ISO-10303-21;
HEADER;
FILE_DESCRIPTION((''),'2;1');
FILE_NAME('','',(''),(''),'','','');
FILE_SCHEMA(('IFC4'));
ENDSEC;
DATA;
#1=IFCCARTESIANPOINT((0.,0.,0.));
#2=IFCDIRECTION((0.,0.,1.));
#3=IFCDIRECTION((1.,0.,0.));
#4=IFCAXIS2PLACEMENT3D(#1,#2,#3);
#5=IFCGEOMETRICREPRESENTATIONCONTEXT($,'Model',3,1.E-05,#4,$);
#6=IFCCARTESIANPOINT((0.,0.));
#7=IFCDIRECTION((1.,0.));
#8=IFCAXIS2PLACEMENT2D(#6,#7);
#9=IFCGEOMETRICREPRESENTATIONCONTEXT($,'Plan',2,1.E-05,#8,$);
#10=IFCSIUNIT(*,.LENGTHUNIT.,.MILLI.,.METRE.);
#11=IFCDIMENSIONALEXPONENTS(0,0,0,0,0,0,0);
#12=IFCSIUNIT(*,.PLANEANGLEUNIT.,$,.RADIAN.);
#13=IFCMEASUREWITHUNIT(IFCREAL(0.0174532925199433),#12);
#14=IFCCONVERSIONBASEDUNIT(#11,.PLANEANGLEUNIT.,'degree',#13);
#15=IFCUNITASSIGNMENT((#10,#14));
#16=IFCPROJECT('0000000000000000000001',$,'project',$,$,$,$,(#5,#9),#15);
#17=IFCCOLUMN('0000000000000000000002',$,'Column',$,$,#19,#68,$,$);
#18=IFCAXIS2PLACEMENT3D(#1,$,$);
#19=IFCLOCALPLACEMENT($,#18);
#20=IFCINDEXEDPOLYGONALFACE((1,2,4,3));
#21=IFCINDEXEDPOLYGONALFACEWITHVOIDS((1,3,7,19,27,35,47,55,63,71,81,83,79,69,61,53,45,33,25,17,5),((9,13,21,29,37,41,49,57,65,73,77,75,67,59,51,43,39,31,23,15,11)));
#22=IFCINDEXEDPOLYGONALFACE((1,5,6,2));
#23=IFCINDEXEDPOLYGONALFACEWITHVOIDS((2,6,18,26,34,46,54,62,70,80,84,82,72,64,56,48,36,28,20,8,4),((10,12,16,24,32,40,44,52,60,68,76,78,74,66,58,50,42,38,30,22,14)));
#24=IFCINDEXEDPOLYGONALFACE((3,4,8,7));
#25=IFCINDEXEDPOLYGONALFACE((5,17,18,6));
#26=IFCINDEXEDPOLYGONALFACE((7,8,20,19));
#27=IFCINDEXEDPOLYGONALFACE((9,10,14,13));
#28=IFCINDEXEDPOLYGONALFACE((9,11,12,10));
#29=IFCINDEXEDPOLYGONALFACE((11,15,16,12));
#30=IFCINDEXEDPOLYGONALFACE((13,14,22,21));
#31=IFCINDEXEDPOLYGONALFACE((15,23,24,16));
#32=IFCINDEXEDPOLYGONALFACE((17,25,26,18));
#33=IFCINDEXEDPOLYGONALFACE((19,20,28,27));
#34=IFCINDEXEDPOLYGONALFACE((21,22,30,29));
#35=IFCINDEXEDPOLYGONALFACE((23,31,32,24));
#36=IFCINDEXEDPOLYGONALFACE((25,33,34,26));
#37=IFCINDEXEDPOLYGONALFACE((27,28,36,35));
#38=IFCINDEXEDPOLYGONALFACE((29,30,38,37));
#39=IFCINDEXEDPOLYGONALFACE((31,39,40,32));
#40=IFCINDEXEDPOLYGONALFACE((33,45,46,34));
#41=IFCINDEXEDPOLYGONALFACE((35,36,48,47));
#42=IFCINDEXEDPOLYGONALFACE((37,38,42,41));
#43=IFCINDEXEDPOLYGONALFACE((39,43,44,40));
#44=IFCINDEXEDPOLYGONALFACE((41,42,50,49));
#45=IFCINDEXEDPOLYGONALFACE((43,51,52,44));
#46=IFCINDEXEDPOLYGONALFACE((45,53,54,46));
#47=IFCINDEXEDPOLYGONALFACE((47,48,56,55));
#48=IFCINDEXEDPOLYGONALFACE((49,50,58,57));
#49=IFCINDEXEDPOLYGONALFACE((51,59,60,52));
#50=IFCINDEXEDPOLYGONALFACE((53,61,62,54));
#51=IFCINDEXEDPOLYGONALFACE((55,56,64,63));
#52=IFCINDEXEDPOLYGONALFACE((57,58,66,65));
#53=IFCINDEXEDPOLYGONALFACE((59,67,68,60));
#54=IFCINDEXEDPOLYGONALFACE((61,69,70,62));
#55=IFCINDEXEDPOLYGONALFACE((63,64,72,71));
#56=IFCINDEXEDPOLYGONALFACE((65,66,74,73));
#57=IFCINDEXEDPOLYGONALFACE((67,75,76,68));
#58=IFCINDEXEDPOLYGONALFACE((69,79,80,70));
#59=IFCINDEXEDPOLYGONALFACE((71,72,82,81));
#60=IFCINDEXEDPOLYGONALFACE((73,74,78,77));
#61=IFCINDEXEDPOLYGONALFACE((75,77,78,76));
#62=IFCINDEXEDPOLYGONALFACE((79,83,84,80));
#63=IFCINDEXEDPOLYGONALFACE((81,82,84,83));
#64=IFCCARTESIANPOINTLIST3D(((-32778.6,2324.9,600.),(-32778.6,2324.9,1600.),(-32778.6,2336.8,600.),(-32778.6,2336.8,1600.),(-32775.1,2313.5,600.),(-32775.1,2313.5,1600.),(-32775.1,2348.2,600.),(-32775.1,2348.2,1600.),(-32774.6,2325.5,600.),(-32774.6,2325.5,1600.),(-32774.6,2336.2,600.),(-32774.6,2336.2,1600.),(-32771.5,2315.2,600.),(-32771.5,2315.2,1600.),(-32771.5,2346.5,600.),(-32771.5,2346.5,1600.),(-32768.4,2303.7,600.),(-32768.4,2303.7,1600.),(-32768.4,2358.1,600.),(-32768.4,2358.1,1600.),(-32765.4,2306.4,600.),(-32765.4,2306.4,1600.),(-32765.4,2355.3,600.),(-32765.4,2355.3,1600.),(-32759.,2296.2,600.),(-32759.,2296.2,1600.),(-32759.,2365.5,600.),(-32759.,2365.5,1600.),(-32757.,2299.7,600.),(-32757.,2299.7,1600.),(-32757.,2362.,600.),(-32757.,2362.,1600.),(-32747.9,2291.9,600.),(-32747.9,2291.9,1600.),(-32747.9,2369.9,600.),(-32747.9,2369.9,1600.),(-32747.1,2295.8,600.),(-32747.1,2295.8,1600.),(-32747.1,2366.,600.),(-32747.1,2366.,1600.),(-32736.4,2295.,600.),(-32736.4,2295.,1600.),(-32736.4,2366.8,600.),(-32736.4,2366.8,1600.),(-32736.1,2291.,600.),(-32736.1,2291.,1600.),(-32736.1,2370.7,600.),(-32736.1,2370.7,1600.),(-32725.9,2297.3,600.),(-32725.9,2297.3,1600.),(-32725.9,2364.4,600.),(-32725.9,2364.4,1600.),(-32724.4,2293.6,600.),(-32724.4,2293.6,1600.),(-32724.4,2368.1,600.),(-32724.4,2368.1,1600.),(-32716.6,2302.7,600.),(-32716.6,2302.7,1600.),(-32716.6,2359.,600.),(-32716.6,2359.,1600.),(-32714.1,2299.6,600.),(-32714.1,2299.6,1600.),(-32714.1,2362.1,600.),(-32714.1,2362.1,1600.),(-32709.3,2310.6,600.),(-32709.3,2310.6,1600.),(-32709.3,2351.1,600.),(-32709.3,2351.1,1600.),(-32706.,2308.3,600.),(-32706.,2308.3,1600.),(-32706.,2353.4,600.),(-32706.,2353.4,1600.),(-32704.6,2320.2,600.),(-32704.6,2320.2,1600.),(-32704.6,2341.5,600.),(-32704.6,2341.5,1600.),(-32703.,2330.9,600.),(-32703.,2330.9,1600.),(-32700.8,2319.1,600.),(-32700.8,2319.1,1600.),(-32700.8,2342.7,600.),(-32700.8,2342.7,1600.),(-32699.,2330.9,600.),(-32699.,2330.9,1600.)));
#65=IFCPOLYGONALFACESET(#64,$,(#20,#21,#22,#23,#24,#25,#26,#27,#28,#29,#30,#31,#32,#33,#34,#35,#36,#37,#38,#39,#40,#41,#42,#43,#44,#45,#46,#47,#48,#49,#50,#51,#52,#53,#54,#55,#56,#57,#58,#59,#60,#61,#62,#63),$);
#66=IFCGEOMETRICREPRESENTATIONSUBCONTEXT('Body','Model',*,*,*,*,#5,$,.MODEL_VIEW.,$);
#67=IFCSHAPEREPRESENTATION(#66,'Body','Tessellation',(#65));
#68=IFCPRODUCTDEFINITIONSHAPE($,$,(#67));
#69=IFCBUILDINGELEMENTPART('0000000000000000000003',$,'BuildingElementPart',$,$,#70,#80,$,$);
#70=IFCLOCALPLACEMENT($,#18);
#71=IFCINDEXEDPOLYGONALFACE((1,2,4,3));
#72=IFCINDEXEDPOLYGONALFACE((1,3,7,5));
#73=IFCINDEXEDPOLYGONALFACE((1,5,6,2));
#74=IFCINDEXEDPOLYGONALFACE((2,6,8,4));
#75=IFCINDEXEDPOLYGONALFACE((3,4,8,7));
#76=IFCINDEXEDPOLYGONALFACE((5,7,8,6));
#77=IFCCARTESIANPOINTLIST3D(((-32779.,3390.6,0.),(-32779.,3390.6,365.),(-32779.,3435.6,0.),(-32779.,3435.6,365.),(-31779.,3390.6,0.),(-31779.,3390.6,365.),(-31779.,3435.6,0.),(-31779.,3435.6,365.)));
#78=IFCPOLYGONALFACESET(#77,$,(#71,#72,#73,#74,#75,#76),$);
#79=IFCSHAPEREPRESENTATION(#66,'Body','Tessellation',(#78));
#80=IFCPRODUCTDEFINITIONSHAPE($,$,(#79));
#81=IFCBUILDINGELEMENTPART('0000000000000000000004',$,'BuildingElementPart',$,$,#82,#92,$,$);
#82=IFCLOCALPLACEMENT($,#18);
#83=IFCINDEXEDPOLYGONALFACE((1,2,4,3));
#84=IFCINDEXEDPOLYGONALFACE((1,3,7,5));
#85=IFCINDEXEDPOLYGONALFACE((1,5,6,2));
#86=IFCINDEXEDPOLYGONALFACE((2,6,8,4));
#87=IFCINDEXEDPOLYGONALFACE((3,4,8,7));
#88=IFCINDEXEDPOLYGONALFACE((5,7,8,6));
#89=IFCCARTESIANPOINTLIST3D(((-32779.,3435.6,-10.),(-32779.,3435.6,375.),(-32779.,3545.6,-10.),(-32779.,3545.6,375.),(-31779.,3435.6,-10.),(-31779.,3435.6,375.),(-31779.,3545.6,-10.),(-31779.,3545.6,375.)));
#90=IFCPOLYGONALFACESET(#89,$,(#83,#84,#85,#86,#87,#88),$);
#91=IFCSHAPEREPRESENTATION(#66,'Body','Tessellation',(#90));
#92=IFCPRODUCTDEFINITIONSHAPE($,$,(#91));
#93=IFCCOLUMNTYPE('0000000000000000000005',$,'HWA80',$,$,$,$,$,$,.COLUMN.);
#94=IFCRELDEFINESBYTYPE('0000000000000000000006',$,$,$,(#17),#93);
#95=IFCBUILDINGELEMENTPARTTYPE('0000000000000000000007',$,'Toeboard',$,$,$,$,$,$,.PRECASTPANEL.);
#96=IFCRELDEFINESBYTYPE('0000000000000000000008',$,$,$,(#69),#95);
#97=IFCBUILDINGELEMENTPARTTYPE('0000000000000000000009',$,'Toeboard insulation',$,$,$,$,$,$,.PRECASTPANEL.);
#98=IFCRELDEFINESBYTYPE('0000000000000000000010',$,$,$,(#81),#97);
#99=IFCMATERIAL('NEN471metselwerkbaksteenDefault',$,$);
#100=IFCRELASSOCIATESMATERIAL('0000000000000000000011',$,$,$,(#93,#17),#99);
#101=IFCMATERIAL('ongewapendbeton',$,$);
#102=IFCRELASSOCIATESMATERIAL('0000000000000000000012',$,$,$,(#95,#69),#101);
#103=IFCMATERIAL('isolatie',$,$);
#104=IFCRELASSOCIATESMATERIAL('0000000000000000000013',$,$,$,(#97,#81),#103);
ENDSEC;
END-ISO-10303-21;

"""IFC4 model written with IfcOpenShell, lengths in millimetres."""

from ifc_helpers import new_model, entity, si_unit, converted_unit, frame, origin_with_axes, origin_2d_with_axis, place, context, subcontext, project, rectangle, hollow_circle, extrude, material, material_profile, profile_set, profile_usage, type_object, element, save


model = new_model("IFC4")

# Units and contexts
model_context = context("Model", 3, precision=1e-05, world=origin_with_axes())
plan_context = context("Plan", 2, precision=1e-05, world=origin_2d_with_axis())
body_context = subcontext(model_context, "Body", "Model", "MODEL_VIEW")
ifc_project = project(units=[si_unit("LENGTHUNIT", "METRE", prefix="MILLI"), converted_unit("PLANEANGLEUNIT", "degree", entity("IfcReal", 0.0174532925199433), si_unit("PLANEANGLEUNIT", "RADIAN"), dimensions=[0, 0, 0, 0, 0, 0, 0])], contexts=[model_context, plan_context])

# Column
ifc_material_1 = material(Name="NEN471metselwerkbaksteenDefault")
ifc_material_profile_1 = material_profile(ifc_material_1, hollow_circle(Radius=40.0, WallThickness=4.0))
ifc_profile_set_1 = profile_set([ifc_material_profile_1])
ifc_profile_usage_1 = profile_usage(ifc_profile_set_1, cardinal=5)
column_type = type_object("IfcColumnType", Name="HWA80", PredefinedType="COLUMN", material=ifc_profile_set_1)
column_placement = place(None, frame((-32739.0, 2330.9, 600.0), z_axis=(0.0, 0.0, 1.0), x_axis=(1.0, 0.0, 0.0)))
element("IfcColumn", 1, at=column_placement, type_object=column_type, material=ifc_profile_usage_1, Name="Column", context=body_context, shape_type="SweptSolid", body=[
    extrude(hollow_circle(Radius=40.0, WallThickness=4.0), origin_with_axes(), (0.0, 0.0, 1.0), 1000.0),
])

# Building element parts
ifc_material_2 = material(Name="ongewapendbeton")
ifc_material_profile_2 = material_profile(ifc_material_2, rectangle(XDim=45.0, YDim=365.0))
ifc_profile_set_2 = profile_set([ifc_material_profile_2], Name="ongewapendbeton")
ifc_profile_usage_2 = profile_usage(ifc_profile_set_2, cardinal=5)
building_element_part_type_1 = type_object("IfcBuildingElementPartType", Name="Toeboard", PredefinedType="PRECASTPANEL", material=ifc_profile_set_2)
building_element_part_1_placement = place(None, frame((-32779.0, 3413.1, 182.5), z_axis=(1.0, 0.0, 0.0), x_axis=(0.0, 1.0, 0.0)))
element("IfcBuildingElementPart", 2, at=building_element_part_1_placement, type_object=building_element_part_type_1, material=ifc_profile_usage_2, Name="BuildingElementPart", context=body_context, shape_type="SweptSolid", body=[
    extrude(rectangle(XDim=45.0, YDim=365.0), origin_with_axes(), (0.0, 0.0, 1.0), 1000.0),
])
ifc_material_3 = material(Name="isolatie")
ifc_material_profile_3 = material_profile(ifc_material_3, rectangle(XDim=110.0, YDim=385.0))
ifc_profile_set_3 = profile_set([ifc_material_profile_3], Name="isolatieEPS")
ifc_profile_usage_3 = profile_usage(ifc_profile_set_3, cardinal=5)
building_element_part_type_2 = type_object("IfcBuildingElementPartType", Name="Toeboard insulation", PredefinedType="PRECASTPANEL", material=ifc_profile_set_3)
building_element_part_2_placement = place(None, frame((-32779.0, 3490.6, 182.5), z_axis=(1.0, 0.0, 0.0), x_axis=(0.0, 1.0, 0.0)))
element("IfcBuildingElementPart", 3, at=building_element_part_2_placement, type_object=building_element_part_type_2, material=ifc_profile_usage_3, Name="BuildingElementPart", context=body_context, shape_type="SweptSolid", body=[
    extrude(rectangle(XDim=110.0, YDim=385.0), origin_with_axes(), (0.0, 0.0, 1.0), 1000.0),
])

save(model, "model.ifc")
